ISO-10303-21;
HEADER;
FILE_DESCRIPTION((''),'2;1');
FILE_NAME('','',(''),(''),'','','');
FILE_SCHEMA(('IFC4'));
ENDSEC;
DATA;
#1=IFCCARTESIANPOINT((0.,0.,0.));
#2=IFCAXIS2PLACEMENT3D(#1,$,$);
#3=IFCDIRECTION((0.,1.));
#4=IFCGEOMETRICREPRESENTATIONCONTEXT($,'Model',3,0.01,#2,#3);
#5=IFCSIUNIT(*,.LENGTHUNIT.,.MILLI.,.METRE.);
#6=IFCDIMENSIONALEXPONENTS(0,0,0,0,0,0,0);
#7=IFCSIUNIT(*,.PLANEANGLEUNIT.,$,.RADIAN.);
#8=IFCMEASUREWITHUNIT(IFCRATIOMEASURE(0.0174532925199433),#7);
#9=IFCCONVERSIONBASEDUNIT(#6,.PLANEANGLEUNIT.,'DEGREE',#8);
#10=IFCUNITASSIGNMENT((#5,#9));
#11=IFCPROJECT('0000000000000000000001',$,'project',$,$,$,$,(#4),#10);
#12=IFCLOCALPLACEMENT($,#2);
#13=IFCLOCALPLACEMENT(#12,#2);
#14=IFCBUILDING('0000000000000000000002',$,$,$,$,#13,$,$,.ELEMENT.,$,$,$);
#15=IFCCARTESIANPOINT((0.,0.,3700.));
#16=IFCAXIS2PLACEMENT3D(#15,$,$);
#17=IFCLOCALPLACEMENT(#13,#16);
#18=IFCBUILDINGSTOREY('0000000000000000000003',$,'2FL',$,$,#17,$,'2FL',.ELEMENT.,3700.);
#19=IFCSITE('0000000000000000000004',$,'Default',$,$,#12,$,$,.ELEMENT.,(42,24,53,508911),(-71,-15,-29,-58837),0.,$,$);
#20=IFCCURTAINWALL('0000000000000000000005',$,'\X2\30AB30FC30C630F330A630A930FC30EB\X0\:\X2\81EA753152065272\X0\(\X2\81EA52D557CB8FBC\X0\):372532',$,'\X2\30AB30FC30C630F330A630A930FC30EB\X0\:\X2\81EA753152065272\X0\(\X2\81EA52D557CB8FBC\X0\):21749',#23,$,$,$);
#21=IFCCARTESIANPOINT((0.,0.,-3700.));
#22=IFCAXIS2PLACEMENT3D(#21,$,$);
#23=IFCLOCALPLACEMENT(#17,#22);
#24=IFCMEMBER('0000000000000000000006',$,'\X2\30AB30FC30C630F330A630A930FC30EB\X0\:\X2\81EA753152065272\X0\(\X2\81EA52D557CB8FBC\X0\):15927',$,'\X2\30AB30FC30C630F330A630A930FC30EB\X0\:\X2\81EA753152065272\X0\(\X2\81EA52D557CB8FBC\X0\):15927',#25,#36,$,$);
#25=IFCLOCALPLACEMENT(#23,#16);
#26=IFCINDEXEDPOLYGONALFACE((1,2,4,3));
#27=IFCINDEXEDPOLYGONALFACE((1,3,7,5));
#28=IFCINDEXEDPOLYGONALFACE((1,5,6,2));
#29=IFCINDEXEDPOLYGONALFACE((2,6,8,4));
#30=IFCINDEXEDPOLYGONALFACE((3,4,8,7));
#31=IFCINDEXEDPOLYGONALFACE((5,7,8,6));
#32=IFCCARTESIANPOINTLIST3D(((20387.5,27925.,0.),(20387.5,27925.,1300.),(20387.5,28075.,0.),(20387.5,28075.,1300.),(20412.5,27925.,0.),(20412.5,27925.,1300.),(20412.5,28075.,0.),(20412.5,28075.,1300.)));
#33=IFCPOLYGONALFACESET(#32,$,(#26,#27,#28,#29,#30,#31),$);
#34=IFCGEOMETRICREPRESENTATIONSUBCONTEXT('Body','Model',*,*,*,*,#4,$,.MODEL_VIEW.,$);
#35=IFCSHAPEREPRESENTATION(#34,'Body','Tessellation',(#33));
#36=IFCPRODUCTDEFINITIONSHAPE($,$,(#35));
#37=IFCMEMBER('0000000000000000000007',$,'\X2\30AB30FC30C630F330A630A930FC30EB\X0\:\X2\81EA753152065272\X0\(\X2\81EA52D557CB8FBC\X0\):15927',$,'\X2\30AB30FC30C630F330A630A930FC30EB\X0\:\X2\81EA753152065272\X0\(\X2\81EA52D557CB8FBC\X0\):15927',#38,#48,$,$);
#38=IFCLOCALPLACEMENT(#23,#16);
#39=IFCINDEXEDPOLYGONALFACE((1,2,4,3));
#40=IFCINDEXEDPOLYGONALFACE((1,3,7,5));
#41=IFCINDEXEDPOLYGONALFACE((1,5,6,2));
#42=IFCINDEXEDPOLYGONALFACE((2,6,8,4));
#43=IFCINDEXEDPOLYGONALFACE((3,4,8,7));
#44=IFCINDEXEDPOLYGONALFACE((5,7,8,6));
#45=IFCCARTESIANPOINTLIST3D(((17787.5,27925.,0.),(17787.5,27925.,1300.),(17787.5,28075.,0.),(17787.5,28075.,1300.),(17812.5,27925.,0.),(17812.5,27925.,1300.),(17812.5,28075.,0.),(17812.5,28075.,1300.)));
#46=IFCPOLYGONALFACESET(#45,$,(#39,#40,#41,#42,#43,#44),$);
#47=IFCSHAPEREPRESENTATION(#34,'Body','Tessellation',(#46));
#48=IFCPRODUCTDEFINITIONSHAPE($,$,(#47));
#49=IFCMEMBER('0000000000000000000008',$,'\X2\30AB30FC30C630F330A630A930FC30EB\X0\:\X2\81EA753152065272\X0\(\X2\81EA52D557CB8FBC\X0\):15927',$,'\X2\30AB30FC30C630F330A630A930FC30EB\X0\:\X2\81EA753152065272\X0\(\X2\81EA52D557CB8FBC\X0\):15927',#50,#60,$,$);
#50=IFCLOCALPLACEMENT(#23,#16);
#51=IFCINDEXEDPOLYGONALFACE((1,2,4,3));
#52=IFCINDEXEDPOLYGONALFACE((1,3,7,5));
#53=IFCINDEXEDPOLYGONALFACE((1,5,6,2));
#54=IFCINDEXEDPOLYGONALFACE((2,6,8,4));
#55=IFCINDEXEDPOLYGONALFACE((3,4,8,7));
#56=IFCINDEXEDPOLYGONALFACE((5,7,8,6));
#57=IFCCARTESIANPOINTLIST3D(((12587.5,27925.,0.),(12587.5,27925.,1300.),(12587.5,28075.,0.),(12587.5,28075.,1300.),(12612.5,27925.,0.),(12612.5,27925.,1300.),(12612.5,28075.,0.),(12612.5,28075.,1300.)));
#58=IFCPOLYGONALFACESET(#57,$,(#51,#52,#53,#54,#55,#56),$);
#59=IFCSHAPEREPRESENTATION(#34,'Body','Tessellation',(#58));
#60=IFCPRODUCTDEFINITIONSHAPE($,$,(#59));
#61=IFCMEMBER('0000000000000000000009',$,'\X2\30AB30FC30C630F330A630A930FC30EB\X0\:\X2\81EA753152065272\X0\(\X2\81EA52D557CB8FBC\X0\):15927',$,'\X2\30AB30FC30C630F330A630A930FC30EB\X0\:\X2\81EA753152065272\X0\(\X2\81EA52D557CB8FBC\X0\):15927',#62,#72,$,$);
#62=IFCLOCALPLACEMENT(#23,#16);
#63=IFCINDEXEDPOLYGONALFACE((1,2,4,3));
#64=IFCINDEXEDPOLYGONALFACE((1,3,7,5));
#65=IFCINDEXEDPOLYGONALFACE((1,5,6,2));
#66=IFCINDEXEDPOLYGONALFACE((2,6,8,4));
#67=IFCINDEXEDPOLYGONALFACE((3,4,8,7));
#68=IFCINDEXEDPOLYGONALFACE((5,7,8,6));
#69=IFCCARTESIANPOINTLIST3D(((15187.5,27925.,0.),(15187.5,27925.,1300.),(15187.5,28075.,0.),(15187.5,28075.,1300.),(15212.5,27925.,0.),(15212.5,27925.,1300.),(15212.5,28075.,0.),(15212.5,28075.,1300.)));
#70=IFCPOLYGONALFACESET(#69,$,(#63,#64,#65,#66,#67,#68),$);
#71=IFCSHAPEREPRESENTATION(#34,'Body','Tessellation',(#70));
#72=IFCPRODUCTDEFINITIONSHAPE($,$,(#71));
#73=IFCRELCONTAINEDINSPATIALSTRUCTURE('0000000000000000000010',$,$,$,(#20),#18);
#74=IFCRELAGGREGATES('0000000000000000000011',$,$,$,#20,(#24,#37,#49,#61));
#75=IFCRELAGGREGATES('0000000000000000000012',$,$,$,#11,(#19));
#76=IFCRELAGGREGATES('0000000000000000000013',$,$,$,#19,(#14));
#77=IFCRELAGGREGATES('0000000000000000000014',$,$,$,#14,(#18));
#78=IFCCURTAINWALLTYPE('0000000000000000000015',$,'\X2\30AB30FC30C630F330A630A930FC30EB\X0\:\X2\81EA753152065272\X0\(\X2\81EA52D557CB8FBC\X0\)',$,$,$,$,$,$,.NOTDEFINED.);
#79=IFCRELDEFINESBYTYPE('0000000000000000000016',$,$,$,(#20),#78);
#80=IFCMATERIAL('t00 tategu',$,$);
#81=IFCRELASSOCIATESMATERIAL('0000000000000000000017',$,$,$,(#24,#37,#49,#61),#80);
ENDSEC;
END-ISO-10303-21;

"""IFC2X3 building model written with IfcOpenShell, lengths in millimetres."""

from ifc_helpers import new_model, entity, si_unit, converted_unit, direction, frame, frame_2d, origin, origin_2d_with_axis, place, context, subcontext, project, spatial, rectangle, extrude, material, type_object, element, aggregate, save


model = new_model("IFC2X3")

# Units and contexts
model_context = context("Model", 3, precision=0.01, world=origin(), true_north=direction((0.0, 1.0)))
body_context = subcontext(model_context, "Body", "Model", "MODEL_VIEW")
ifc_project = project(units=[si_unit("LENGTHUNIT", "METRE", prefix="MILLI"), converted_unit("PLANEANGLEUNIT", "DEGREE", entity("IfcRatioMeasure", 0.0174532925199433), si_unit("PLANEANGLEUNIT", "RADIAN"), dimensions=[0, 0, 0, 0, 0, 0, 0])], contexts=[model_context])

# Site, building, storey
site_placement = place(None, origin())
site = spatial("IfcSite", under=ifc_project, at=site_placement, Name="Default", CompositionType="ELEMENT", RefLatitude=(42, 24, 53, 508911), RefLongitude=(-71, -15, -29, -58837), RefElevation=0.0)
building_placement = place(site_placement, origin())
building = spatial("IfcBuilding", under=site, at=building_placement, CompositionType="ELEMENT")
storey_placement = place(building_placement, frame((0.0, 0.0, 3700.0)))
storey = spatial("IfcBuildingStorey", under=building, at=storey_placement, Name="2FL", LongName="2FL", CompositionType="ELEMENT", Elevation=3700.0)

# Curtain wall, members
curtain_wall_type = type_object("IfcCurtainWallType", Name="カーテンウォール:自由分割(自動埋込)", PredefinedType="NOTDEFINED")
curtain_wall_1_placement = place(storey_placement, frame((0.0, 0.0, -3700.0)))
curtain_wall_1 = element("IfcCurtainWall", 1, at=curtain_wall_1_placement, inside=storey, type_object=curtain_wall_type, Name="カーテンウォール:自由分割(自動埋込):372532", ObjectType="カーテンウォール:自由分割(自動埋込):21749")
ifc_material = material(Name="t00 tategu")
member_1_placement = place(curtain_wall_1_placement, frame((0.0, 0.0, 3700.0)))
member_1 = element("IfcMember", 2, at=member_1_placement, material=ifc_material, Name="カーテンウォール:自由分割(自動埋込):15927", ObjectType="カーテンウォール:自由分割(自動埋込):15927", context=body_context, shape_type="SweptSolid", body=[
    extrude(rectangle(XDim=25.0, YDim=150.0, at=origin_2d_with_axis()), frame((20400.0, 28000.0, 0.0), z_axis=(0.0, 0.0, 1.0), x_axis=(-1.0, 0.0, 0.0)), (0.0, 0.0, 1.0), 1300.0),
])
member_2_placement = place(curtain_wall_1_placement, frame((0.0, 0.0, 3700.0)))
member_2 = element("IfcMember", 3, at=member_2_placement, material=ifc_material, Name="カーテンウォール:自由分割(自動埋込):15927", ObjectType="カーテンウォール:自由分割(自動埋込):15927", context=body_context, shape_type="SweptSolid", body=[
    extrude(rectangle(XDim=25.0, YDim=150.0, at=origin_2d_with_axis()), frame((17800.0, 28000.0, 0.0), z_axis=(0.0, 0.0, 1.0), x_axis=(-1.0, 0.0, 0.0)), (0.0, 0.0, 1.0), 1300.0),
])
member_3_placement = place(curtain_wall_1_placement, frame((0.0, 0.0, 3700.0)))
member_3 = element("IfcMember", 4, at=member_3_placement, material=ifc_material, Name="カーテンウォール:自由分割(自動埋込):15927", ObjectType="カーテンウォール:自由分割(自動埋込):15927", context=body_context, shape_type="SweptSolid", body=[
    extrude(rectangle(XDim=25.0, YDim=150.0, at=origin_2d_with_axis()), frame((12600.0, 28000.0, 0.0), z_axis=(0.0, 0.0, 1.0), x_axis=(-1.0, 0.0, 0.0)), (0.0, 0.0, 1.0), 1300.0),
])
member_4_placement = place(curtain_wall_1_placement, frame((0.0, 0.0, 3700.0)))
member_4 = element("IfcMember", 5, at=member_4_placement, material=ifc_material, Name="カーテンウォール:自由分割(自動埋込):15927", ObjectType="カーテンウォール:自由分割(自動埋込):15927", context=body_context, shape_type="SweptSolid", body=[
    extrude(rectangle(XDim=25.0, YDim=150.0, at=frame_2d((0.0, 0.0), x_axis=(1.0, 0.0))), frame((15200.0, 28000.0, 0.0), z_axis=(0.0, 0.0, 1.0), x_axis=(-1.0, 0.0, 0.0)), (0.0, 0.0, 1.0), 1300.0),
])
aggregate(curtain_wall_1, [member_1, member_2, member_3, member_4])

save(model, "model.ifc")
